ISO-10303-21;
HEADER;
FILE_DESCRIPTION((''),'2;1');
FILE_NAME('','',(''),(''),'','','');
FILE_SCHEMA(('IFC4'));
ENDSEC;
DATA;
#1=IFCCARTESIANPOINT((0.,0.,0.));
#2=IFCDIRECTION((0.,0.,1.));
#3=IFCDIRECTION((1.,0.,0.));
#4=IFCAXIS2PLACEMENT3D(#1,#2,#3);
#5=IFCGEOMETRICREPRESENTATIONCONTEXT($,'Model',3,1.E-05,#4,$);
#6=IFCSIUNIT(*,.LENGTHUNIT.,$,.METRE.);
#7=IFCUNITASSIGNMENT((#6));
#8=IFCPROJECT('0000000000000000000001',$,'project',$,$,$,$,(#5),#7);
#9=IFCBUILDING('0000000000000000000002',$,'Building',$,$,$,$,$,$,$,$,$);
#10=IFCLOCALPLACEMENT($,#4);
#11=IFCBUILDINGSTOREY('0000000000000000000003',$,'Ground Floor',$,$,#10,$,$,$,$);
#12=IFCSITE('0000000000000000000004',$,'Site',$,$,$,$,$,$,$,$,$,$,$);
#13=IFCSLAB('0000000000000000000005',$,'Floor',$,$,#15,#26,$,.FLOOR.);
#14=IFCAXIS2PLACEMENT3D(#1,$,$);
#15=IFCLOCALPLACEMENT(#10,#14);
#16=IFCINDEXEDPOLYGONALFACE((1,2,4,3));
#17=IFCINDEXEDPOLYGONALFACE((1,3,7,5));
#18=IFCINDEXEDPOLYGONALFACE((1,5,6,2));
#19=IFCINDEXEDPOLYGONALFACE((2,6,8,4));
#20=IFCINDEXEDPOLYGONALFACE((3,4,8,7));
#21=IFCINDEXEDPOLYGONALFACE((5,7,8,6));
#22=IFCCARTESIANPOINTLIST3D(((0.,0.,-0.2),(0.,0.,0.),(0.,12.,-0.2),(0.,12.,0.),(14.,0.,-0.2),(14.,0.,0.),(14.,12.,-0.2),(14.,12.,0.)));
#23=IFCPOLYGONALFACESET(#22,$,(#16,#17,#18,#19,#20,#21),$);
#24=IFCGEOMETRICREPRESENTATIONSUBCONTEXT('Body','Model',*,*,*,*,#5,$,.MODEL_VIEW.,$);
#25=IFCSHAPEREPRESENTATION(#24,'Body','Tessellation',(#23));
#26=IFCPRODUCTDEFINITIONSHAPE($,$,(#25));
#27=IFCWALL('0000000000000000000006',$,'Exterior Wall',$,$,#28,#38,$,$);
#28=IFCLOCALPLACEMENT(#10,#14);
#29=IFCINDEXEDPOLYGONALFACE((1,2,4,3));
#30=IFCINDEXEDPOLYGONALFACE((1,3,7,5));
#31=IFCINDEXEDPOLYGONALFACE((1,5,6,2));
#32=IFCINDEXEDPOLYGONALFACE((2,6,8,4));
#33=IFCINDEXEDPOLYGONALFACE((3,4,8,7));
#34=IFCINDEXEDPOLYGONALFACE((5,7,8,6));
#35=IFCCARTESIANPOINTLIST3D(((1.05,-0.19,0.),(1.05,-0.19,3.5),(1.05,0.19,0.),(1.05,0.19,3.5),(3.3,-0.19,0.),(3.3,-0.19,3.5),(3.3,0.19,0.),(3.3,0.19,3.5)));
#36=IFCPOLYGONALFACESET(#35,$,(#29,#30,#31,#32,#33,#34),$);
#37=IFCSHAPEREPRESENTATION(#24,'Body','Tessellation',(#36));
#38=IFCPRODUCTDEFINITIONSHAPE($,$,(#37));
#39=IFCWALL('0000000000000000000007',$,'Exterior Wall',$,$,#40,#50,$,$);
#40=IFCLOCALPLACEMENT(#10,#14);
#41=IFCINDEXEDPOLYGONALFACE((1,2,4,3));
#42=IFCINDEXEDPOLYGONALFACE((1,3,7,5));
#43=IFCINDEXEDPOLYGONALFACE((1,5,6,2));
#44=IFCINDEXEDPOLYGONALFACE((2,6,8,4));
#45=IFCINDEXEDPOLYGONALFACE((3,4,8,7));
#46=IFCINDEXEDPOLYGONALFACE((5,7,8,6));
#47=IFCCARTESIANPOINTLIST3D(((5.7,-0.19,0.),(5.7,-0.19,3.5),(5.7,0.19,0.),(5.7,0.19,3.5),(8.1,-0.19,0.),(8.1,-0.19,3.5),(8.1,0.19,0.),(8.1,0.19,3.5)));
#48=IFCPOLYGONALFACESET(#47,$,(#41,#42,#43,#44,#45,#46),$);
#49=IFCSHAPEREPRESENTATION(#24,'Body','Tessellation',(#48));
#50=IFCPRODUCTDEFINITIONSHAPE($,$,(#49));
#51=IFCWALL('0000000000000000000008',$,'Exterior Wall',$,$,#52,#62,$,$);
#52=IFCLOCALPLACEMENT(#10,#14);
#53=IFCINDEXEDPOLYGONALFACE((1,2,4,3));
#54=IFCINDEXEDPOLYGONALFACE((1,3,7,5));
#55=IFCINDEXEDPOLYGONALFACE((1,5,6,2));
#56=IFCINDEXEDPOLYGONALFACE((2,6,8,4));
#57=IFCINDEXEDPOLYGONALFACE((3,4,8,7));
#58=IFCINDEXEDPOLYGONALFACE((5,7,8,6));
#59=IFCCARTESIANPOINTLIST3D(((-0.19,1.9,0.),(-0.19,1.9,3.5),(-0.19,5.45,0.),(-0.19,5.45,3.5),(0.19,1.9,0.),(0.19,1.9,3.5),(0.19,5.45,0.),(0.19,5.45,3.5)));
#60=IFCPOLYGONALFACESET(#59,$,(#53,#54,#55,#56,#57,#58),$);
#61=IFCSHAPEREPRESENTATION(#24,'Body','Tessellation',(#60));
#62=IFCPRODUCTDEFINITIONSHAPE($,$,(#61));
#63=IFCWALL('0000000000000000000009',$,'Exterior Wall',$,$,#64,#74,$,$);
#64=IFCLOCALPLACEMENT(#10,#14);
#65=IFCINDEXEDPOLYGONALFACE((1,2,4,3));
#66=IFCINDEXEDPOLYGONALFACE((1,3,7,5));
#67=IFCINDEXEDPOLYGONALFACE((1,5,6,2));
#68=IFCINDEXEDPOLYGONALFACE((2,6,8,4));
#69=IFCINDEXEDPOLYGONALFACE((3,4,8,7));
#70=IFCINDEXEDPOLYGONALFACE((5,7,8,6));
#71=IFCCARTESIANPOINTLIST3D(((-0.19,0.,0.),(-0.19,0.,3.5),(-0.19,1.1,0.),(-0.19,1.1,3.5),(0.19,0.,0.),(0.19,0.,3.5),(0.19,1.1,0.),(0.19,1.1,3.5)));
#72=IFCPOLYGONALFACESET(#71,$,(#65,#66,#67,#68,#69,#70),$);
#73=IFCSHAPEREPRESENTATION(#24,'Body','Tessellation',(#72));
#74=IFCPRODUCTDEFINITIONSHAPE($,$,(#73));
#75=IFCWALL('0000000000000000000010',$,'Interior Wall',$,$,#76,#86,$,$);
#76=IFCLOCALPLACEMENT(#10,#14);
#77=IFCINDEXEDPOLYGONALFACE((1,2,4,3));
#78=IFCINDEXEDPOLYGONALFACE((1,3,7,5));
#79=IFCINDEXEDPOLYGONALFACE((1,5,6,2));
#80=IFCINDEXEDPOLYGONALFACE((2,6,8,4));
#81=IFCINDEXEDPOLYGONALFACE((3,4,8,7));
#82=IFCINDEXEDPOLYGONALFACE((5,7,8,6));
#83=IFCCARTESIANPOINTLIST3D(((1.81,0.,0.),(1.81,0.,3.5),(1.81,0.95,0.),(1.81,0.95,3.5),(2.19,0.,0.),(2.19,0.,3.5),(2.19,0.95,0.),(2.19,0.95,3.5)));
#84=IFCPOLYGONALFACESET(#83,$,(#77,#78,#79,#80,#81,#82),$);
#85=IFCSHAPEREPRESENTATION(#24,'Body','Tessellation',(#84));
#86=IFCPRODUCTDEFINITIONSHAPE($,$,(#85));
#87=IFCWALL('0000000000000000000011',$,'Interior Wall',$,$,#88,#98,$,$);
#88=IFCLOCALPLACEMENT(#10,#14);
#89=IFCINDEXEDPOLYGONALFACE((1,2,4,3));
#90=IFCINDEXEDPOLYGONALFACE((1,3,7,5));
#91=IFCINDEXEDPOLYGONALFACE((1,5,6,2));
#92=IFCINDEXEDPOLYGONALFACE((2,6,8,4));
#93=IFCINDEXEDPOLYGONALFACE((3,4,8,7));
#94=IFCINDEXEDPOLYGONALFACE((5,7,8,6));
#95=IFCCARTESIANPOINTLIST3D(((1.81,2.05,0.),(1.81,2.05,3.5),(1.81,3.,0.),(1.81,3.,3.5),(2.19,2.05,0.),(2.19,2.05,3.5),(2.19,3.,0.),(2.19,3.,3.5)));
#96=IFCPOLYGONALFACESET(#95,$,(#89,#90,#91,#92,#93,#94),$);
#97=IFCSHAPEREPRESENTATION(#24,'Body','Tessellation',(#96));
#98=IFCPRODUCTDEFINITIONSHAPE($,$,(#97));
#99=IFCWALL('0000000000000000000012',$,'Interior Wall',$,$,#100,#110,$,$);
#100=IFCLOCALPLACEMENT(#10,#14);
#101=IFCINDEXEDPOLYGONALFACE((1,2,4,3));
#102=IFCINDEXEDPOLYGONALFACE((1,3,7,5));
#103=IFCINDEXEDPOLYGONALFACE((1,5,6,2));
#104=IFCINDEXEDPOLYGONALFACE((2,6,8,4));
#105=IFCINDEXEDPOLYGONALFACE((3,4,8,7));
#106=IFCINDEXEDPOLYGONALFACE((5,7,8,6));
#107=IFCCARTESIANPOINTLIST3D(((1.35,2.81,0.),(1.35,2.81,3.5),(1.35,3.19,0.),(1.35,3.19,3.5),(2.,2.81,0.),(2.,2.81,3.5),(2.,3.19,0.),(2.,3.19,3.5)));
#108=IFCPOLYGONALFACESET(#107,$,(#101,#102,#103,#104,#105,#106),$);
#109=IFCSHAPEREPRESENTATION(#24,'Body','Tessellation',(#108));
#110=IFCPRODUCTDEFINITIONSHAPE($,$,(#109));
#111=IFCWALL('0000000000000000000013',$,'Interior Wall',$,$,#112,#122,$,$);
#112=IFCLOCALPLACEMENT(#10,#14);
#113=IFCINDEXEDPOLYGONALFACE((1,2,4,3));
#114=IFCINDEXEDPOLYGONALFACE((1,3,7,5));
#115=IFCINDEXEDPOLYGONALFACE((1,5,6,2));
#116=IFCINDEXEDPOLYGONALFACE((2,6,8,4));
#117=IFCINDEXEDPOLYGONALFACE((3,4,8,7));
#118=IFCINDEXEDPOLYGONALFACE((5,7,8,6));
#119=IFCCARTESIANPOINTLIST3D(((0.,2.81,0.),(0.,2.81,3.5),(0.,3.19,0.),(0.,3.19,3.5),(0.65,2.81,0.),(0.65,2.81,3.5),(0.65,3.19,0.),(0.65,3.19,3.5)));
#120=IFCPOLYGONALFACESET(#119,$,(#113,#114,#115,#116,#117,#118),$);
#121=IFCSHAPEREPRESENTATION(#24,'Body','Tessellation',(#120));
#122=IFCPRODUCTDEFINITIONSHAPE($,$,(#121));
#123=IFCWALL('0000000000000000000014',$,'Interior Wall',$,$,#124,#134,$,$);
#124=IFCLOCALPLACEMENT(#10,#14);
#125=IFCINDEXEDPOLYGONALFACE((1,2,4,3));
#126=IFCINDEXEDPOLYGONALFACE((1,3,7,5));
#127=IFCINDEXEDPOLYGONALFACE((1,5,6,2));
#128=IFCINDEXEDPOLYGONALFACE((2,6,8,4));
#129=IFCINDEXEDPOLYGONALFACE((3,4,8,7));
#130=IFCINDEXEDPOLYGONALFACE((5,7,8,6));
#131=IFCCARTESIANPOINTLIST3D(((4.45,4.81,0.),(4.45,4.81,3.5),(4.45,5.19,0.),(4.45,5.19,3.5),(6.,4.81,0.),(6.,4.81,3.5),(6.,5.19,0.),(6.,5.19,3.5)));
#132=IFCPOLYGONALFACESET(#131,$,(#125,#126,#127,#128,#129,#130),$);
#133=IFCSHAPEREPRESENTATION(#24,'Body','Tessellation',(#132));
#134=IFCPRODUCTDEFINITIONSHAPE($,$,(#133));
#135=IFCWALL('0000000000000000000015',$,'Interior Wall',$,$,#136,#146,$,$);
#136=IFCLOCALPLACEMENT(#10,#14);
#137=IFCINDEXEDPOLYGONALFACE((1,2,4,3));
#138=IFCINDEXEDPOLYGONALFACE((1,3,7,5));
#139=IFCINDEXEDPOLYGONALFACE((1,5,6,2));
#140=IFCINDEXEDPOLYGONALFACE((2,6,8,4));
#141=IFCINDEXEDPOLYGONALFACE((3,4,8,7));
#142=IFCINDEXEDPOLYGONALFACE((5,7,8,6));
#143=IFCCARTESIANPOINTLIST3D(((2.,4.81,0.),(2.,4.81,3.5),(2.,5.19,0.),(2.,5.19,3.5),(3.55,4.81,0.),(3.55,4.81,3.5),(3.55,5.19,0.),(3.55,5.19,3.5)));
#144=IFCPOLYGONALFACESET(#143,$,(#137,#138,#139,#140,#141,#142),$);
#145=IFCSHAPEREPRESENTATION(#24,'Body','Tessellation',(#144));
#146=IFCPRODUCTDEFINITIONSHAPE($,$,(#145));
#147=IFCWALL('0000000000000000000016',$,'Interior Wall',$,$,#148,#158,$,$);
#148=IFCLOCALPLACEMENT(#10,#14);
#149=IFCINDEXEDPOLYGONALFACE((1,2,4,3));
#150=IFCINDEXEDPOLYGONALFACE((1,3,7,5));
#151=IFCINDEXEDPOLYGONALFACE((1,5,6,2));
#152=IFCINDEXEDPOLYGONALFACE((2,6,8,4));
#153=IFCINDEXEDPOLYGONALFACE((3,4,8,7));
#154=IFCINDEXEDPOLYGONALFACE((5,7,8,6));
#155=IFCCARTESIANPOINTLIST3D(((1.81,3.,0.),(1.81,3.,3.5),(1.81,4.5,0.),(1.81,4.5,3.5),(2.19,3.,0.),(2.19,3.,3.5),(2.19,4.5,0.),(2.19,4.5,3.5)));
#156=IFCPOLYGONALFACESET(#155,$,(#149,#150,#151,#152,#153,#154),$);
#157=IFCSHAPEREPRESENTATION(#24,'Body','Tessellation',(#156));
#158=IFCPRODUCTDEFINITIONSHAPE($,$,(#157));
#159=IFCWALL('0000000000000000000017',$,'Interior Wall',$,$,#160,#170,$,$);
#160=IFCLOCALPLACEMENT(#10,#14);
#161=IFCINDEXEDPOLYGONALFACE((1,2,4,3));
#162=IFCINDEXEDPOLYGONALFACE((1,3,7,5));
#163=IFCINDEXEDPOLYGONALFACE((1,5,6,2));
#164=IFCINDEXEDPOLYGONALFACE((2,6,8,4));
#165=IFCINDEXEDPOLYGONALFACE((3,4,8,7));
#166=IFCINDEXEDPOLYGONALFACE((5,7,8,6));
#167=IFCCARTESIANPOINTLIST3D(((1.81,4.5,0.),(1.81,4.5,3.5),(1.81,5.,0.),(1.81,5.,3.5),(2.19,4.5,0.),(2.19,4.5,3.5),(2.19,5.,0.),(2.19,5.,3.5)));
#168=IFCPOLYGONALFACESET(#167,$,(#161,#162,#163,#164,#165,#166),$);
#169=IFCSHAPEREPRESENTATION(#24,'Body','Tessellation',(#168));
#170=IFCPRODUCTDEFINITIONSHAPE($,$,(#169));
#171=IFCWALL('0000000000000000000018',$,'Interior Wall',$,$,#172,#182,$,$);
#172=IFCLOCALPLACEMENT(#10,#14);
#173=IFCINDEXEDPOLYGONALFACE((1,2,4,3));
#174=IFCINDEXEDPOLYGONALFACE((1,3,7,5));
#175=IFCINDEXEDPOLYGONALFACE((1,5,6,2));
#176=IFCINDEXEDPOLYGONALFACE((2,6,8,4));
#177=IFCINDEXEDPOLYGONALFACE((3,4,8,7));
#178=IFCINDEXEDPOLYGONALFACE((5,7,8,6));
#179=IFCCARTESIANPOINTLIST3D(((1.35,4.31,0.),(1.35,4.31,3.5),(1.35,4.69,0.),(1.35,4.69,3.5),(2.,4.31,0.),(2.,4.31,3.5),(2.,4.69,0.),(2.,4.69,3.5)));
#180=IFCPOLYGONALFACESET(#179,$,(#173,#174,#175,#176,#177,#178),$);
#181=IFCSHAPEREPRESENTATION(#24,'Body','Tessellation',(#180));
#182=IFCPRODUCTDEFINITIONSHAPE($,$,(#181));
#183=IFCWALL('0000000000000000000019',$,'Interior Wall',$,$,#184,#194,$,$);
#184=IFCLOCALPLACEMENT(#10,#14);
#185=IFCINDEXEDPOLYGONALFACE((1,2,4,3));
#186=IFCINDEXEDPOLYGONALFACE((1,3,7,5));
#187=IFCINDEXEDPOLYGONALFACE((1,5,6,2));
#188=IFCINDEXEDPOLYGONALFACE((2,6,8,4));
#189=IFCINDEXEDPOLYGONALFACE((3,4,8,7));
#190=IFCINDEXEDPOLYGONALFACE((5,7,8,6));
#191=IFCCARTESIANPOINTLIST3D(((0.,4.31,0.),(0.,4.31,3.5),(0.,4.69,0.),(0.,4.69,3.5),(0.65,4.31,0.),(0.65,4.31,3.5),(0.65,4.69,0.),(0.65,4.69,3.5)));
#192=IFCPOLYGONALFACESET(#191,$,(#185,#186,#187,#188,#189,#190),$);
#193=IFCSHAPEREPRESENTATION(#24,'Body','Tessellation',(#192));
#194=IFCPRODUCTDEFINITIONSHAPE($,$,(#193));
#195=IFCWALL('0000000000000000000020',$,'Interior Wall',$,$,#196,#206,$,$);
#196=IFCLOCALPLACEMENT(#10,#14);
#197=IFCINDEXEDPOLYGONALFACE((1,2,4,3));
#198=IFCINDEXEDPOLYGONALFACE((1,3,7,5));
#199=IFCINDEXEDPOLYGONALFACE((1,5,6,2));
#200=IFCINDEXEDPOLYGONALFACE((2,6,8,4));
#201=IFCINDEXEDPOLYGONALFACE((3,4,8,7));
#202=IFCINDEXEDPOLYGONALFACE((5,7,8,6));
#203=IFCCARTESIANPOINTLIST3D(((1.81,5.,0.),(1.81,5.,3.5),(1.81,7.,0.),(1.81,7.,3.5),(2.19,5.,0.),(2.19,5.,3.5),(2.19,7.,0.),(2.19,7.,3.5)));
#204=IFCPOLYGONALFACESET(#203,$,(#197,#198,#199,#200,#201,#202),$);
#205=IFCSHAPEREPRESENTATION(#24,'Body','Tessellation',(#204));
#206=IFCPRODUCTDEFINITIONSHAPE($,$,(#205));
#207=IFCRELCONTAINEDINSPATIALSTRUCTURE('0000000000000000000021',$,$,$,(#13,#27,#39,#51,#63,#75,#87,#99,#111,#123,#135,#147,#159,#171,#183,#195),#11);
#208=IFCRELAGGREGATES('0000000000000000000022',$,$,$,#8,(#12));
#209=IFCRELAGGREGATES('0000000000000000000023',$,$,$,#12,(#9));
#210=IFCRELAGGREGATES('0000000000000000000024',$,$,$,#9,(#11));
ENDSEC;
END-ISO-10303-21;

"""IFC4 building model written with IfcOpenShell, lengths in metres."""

from ifc_helpers import new_model, si_unit, frame, origin_with_axes, place, context, subcontext, project, spatial, indexed_curve, outline, extrude, element, save


model = new_model("IFC4")

# Units and contexts
model_context = context("Model", 3, precision=1e-05, world=origin_with_axes())
body_context = subcontext(model_context, "Body", "Model", "MODEL_VIEW")
ifc_project = project(units=[si_unit("LENGTHUNIT", "METRE")], contexts=[model_context])

# Site, building, storey
site = spatial("IfcSite", under=ifc_project, Name="Site")
building = spatial("IfcBuilding", under=site, Name="Building")
storey_placement = place(None, origin_with_axes())
storey = spatial("IfcBuildingStorey", under=building, at=storey_placement, Name="Ground Floor")

# Slab
slab_placement = place(storey_placement, frame((0.0, 0.0, -0.2), z_axis=(0.0, 0.0, 1.0), x_axis=(1.0, 0.0, 0.0)))
element("IfcSlab", 1, at=slab_placement, inside=storey, Name="Floor", PredefinedType="FLOOR", context=body_context, shape_type="SweptSolid", body=[
    extrude(outline(indexed_curve([(0.0, 0.0), (14.0, 0.0), (14.0, 12.0), (0.0, 12.0)])), None, (0.0, 0.0, 1.0), 0.2),
])

# Walls
wall_1_placement = place(storey_placement, frame((1.05, 0.0, 0.0), z_axis=(0.0, 0.0, 1.0), x_axis=(1.0, 0.0, 0.0)))
element("IfcWall", 2, at=wall_1_placement, inside=storey, Name="Exterior Wall", context=body_context, shape_type="SweptSolid", body=[
    extrude(outline(indexed_curve([(0.0, 0.0), (0.0, 0.38), (2.25, 0.38), (2.25, 0.0), (0.0, 0.0)], self_intersect=False)), frame((0.0, -0.19, 0.0), z_axis=(0.0, 0.0, 1.0), x_axis=(1.0, 0.0, 0.0)), (0.0, 0.0, 1.0), 3.5),
])
wall_2_placement = place(storey_placement, frame((5.7, 0.0, 0.0), z_axis=(0.0, 0.0, 1.0), x_axis=(1.0, 0.0, 0.0)))
element("IfcWall", 3, at=wall_2_placement, inside=storey, Name="Exterior Wall", context=body_context, shape_type="SweptSolid", body=[
    extrude(outline(indexed_curve([(0.0, 0.0), (0.0, 0.38), (2.4, 0.38), (2.4, 0.0), (0.0, 0.0)], self_intersect=False)), frame((0.0, -0.19, 0.0), z_axis=(0.0, 0.0, 1.0), x_axis=(1.0, 0.0, 0.0)), (0.0, 0.0, 1.0), 3.5),
])
wall_3_placement = place(storey_placement, frame((0.0, 5.45, 0.0), z_axis=(0.0, 0.0, 1.0), x_axis=(0.0, -1.0, 0.0)))
element("IfcWall", 4, at=wall_3_placement, inside=storey, Name="Exterior Wall", context=body_context, shape_type="SweptSolid", body=[
    extrude(outline(indexed_curve([(0.0, 0.0), (0.0, 0.38), (3.55, 0.38), (3.55, 0.0), (0.0, 0.0)], self_intersect=False)), frame((0.0, -0.19, 0.0), z_axis=(0.0, 0.0, 1.0), x_axis=(1.0, 0.0, 0.0)), (0.0, 0.0, 1.0), 3.5),
])
wall_4_placement = place(storey_placement, frame((0.0, 1.1, 0.0), z_axis=(0.0, 0.0, 1.0), x_axis=(0.0, -1.0, 0.0)))
element("IfcWall", 5, at=wall_4_placement, inside=storey, Name="Exterior Wall", context=body_context, shape_type="SweptSolid", body=[
    extrude(outline(indexed_curve([(0.0, 0.0), (0.0, 0.38), (1.1, 0.38), (1.1, 0.0), (0.0, 0.0)], self_intersect=False)), frame((0.0, -0.19, 0.0), z_axis=(0.0, 0.0, 1.0), x_axis=(1.0, 0.0, 0.0)), (0.0, 0.0, 1.0), 3.5),
])
wall_5_placement = place(storey_placement, frame((2.0, 0.0, 0.0), z_axis=(0.0, 0.0, 1.0), x_axis=(0.0, 1.0, 0.0)))
element("IfcWall", 6, at=wall_5_placement, inside=storey, Name="Interior Wall", context=body_context, shape_type="SweptSolid", body=[
    extrude(outline(indexed_curve([(0.0, 0.0), (0.0, 0.38), (0.95, 0.38), (0.95, 0.0), (0.0, 0.0)], self_intersect=False)), frame((0.0, -0.19, 0.0), z_axis=(0.0, 0.0, 1.0), x_axis=(1.0, 0.0, 0.0)), (0.0, 0.0, 1.0), 3.5),
])
wall_6_placement = place(storey_placement, frame((2.0, 2.05, 0.0), z_axis=(0.0, 0.0, 1.0), x_axis=(0.0, 1.0, 0.0)))
element("IfcWall", 7, at=wall_6_placement, inside=storey, Name="Interior Wall", context=body_context, shape_type="SweptSolid", body=[
    extrude(outline(indexed_curve([(0.0, 0.0), (0.0, 0.38), (0.95, 0.38), (0.95, 0.0), (0.0, 0.0)], self_intersect=False)), frame((0.0, -0.19, 0.0), z_axis=(0.0, 0.0, 1.0), x_axis=(1.0, 0.0, 0.0)), (0.0, 0.0, 1.0), 3.5),
])
for number, where, z_axis, x_axis, name in (
    (8, (2.0, 3.0, 0.0), (0.0, 0.0, 1.0), (-1.0, 0.0, 0.0), "Interior Wall"),
    (9, (0.65, 3.0, 0.0), (0.0, 0.0, 1.0), (-1.0, 0.0, 0.0), "Interior Wall"),
):
    element("IfcWall", number, at=place(storey_placement, frame(where, z_axis=z_axis, x_axis=x_axis)), inside=storey, Name=name, context=body_context, shape_type="SweptSolid", body=[
        extrude(outline(indexed_curve([(0.0, 0.0), (0.0, 0.38), (0.65, 0.38), (0.65, 0.0), (0.0, 0.0)], self_intersect=False)), frame((0.0, -0.19, 0.0), z_axis=(0.0, 0.0, 1.0), x_axis=(1.0, 0.0, 0.0)), (0.0, 0.0, 1.0), 3.5),
    ])
for number, where, z_axis, x_axis, name in (
    (10, (6.0, 5.0, 0.0), (0.0, 0.0, 1.0), (-1.0, 0.0, 0.0), "Interior Wall"),
    (11, (3.55, 5.0, 0.0), (0.0, 0.0, 1.0), (-1.0, 0.0, 0.0), "Interior Wall"),
):
    element("IfcWall", number, at=place(storey_placement, frame(where, z_axis=z_axis, x_axis=x_axis)), inside=storey, Name=name, context=body_context, shape_type="SweptSolid", body=[
        extrude(outline(indexed_curve([(0.0, 0.0), (0.0, 0.38), (1.55, 0.38), (1.55, 0.0), (0.0, 0.0)], self_intersect=False)), frame((0.0, -0.19, 0.0), z_axis=(0.0, 0.0, 1.0), x_axis=(1.0, 0.0, 0.0)), (0.0, 0.0, 1.0), 3.5),
    ])
wall_7_placement = place(storey_placement, frame((2.0, 4.5, 0.0), z_axis=(0.0, 0.0, 1.0), x_axis=(0.0, -1.0, 0.0)))
element("IfcWall", 12, at=wall_7_placement, inside=storey, Name="Interior Wall", context=body_context, shape_type="SweptSolid", body=[
    extrude(outline(indexed_curve([(0.0, 0.0), (0.0, 0.38), (1.5, 0.38), (1.5, 0.0), (0.0, 0.0)], self_intersect=False)), frame((0.0, -0.19, 0.0), z_axis=(0.0, 0.0, 1.0), x_axis=(1.0, 0.0, 0.0)), (0.0, 0.0, 1.0), 3.5),
])
wall_8_placement = place(storey_placement, frame((2.0, 5.0, 0.0), z_axis=(0.0, 0.0, 1.0), x_axis=(0.0, -1.0, 0.0)))
element("IfcWall", 13, at=wall_8_placement, inside=storey, Name="Interior Wall", context=body_context, shape_type="SweptSolid", body=[
    extrude(outline(indexed_curve([(0.0, 0.0), (0.0, 0.38), (0.5, 0.38), (0.5, 0.0), (0.0, 0.0)], self_intersect=False)), frame((0.0, -0.19, 0.0), z_axis=(0.0, 0.0, 1.0), x_axis=(1.0, 0.0, 0.0)), (0.0, 0.0, 1.0), 3.5),
])
for number, where, z_axis, x_axis, name in (
    (14, (2.0, 4.5, 0.0), (0.0, 0.0, 1.0), (-1.0, 0.0, 0.0), "Interior Wall"),
    (15, (0.65, 4.5, 0.0), (0.0, 0.0, 1.0), (-1.0, 0.0, 0.0), "Interior Wall"),
):
    element("IfcWall", number, at=place(storey_placement, frame(where, z_axis=z_axis, x_axis=x_axis)), inside=storey, Name=name, context=body_context, shape_type="SweptSolid", body=[
        extrude(outline(indexed_curve([(0.0, 0.0), (0.0, 0.38), (0.65, 0.38), (0.65, 0.0), (0.0, 0.0)], self_intersect=False)), frame((0.0, -0.19, 0.0), z_axis=(0.0, 0.0, 1.0), x_axis=(1.0, 0.0, 0.0)), (0.0, 0.0, 1.0), 3.5),
    ])
wall_9_placement = place(storey_placement, frame((2.0, 5.0, 0.0), z_axis=(0.0, 0.0, 1.0), x_axis=(0.0, 1.0, 0.0)))
element("IfcWall", 16, at=wall_9_placement, inside=storey, Name="Interior Wall", context=body_context, shape_type="SweptSolid", body=[
    extrude(outline(indexed_curve([(0.0, 0.0), (0.0, 0.38), (2.0, 0.38), (2.0, 0.0), (0.0, 0.0)], self_intersect=False)), frame((0.0, -0.19, 0.0), z_axis=(0.0, 0.0, 1.0), x_axis=(1.0, 0.0, 0.0)), (0.0, 0.0, 1.0), 3.5),
])

save(model, "model.ifc")
